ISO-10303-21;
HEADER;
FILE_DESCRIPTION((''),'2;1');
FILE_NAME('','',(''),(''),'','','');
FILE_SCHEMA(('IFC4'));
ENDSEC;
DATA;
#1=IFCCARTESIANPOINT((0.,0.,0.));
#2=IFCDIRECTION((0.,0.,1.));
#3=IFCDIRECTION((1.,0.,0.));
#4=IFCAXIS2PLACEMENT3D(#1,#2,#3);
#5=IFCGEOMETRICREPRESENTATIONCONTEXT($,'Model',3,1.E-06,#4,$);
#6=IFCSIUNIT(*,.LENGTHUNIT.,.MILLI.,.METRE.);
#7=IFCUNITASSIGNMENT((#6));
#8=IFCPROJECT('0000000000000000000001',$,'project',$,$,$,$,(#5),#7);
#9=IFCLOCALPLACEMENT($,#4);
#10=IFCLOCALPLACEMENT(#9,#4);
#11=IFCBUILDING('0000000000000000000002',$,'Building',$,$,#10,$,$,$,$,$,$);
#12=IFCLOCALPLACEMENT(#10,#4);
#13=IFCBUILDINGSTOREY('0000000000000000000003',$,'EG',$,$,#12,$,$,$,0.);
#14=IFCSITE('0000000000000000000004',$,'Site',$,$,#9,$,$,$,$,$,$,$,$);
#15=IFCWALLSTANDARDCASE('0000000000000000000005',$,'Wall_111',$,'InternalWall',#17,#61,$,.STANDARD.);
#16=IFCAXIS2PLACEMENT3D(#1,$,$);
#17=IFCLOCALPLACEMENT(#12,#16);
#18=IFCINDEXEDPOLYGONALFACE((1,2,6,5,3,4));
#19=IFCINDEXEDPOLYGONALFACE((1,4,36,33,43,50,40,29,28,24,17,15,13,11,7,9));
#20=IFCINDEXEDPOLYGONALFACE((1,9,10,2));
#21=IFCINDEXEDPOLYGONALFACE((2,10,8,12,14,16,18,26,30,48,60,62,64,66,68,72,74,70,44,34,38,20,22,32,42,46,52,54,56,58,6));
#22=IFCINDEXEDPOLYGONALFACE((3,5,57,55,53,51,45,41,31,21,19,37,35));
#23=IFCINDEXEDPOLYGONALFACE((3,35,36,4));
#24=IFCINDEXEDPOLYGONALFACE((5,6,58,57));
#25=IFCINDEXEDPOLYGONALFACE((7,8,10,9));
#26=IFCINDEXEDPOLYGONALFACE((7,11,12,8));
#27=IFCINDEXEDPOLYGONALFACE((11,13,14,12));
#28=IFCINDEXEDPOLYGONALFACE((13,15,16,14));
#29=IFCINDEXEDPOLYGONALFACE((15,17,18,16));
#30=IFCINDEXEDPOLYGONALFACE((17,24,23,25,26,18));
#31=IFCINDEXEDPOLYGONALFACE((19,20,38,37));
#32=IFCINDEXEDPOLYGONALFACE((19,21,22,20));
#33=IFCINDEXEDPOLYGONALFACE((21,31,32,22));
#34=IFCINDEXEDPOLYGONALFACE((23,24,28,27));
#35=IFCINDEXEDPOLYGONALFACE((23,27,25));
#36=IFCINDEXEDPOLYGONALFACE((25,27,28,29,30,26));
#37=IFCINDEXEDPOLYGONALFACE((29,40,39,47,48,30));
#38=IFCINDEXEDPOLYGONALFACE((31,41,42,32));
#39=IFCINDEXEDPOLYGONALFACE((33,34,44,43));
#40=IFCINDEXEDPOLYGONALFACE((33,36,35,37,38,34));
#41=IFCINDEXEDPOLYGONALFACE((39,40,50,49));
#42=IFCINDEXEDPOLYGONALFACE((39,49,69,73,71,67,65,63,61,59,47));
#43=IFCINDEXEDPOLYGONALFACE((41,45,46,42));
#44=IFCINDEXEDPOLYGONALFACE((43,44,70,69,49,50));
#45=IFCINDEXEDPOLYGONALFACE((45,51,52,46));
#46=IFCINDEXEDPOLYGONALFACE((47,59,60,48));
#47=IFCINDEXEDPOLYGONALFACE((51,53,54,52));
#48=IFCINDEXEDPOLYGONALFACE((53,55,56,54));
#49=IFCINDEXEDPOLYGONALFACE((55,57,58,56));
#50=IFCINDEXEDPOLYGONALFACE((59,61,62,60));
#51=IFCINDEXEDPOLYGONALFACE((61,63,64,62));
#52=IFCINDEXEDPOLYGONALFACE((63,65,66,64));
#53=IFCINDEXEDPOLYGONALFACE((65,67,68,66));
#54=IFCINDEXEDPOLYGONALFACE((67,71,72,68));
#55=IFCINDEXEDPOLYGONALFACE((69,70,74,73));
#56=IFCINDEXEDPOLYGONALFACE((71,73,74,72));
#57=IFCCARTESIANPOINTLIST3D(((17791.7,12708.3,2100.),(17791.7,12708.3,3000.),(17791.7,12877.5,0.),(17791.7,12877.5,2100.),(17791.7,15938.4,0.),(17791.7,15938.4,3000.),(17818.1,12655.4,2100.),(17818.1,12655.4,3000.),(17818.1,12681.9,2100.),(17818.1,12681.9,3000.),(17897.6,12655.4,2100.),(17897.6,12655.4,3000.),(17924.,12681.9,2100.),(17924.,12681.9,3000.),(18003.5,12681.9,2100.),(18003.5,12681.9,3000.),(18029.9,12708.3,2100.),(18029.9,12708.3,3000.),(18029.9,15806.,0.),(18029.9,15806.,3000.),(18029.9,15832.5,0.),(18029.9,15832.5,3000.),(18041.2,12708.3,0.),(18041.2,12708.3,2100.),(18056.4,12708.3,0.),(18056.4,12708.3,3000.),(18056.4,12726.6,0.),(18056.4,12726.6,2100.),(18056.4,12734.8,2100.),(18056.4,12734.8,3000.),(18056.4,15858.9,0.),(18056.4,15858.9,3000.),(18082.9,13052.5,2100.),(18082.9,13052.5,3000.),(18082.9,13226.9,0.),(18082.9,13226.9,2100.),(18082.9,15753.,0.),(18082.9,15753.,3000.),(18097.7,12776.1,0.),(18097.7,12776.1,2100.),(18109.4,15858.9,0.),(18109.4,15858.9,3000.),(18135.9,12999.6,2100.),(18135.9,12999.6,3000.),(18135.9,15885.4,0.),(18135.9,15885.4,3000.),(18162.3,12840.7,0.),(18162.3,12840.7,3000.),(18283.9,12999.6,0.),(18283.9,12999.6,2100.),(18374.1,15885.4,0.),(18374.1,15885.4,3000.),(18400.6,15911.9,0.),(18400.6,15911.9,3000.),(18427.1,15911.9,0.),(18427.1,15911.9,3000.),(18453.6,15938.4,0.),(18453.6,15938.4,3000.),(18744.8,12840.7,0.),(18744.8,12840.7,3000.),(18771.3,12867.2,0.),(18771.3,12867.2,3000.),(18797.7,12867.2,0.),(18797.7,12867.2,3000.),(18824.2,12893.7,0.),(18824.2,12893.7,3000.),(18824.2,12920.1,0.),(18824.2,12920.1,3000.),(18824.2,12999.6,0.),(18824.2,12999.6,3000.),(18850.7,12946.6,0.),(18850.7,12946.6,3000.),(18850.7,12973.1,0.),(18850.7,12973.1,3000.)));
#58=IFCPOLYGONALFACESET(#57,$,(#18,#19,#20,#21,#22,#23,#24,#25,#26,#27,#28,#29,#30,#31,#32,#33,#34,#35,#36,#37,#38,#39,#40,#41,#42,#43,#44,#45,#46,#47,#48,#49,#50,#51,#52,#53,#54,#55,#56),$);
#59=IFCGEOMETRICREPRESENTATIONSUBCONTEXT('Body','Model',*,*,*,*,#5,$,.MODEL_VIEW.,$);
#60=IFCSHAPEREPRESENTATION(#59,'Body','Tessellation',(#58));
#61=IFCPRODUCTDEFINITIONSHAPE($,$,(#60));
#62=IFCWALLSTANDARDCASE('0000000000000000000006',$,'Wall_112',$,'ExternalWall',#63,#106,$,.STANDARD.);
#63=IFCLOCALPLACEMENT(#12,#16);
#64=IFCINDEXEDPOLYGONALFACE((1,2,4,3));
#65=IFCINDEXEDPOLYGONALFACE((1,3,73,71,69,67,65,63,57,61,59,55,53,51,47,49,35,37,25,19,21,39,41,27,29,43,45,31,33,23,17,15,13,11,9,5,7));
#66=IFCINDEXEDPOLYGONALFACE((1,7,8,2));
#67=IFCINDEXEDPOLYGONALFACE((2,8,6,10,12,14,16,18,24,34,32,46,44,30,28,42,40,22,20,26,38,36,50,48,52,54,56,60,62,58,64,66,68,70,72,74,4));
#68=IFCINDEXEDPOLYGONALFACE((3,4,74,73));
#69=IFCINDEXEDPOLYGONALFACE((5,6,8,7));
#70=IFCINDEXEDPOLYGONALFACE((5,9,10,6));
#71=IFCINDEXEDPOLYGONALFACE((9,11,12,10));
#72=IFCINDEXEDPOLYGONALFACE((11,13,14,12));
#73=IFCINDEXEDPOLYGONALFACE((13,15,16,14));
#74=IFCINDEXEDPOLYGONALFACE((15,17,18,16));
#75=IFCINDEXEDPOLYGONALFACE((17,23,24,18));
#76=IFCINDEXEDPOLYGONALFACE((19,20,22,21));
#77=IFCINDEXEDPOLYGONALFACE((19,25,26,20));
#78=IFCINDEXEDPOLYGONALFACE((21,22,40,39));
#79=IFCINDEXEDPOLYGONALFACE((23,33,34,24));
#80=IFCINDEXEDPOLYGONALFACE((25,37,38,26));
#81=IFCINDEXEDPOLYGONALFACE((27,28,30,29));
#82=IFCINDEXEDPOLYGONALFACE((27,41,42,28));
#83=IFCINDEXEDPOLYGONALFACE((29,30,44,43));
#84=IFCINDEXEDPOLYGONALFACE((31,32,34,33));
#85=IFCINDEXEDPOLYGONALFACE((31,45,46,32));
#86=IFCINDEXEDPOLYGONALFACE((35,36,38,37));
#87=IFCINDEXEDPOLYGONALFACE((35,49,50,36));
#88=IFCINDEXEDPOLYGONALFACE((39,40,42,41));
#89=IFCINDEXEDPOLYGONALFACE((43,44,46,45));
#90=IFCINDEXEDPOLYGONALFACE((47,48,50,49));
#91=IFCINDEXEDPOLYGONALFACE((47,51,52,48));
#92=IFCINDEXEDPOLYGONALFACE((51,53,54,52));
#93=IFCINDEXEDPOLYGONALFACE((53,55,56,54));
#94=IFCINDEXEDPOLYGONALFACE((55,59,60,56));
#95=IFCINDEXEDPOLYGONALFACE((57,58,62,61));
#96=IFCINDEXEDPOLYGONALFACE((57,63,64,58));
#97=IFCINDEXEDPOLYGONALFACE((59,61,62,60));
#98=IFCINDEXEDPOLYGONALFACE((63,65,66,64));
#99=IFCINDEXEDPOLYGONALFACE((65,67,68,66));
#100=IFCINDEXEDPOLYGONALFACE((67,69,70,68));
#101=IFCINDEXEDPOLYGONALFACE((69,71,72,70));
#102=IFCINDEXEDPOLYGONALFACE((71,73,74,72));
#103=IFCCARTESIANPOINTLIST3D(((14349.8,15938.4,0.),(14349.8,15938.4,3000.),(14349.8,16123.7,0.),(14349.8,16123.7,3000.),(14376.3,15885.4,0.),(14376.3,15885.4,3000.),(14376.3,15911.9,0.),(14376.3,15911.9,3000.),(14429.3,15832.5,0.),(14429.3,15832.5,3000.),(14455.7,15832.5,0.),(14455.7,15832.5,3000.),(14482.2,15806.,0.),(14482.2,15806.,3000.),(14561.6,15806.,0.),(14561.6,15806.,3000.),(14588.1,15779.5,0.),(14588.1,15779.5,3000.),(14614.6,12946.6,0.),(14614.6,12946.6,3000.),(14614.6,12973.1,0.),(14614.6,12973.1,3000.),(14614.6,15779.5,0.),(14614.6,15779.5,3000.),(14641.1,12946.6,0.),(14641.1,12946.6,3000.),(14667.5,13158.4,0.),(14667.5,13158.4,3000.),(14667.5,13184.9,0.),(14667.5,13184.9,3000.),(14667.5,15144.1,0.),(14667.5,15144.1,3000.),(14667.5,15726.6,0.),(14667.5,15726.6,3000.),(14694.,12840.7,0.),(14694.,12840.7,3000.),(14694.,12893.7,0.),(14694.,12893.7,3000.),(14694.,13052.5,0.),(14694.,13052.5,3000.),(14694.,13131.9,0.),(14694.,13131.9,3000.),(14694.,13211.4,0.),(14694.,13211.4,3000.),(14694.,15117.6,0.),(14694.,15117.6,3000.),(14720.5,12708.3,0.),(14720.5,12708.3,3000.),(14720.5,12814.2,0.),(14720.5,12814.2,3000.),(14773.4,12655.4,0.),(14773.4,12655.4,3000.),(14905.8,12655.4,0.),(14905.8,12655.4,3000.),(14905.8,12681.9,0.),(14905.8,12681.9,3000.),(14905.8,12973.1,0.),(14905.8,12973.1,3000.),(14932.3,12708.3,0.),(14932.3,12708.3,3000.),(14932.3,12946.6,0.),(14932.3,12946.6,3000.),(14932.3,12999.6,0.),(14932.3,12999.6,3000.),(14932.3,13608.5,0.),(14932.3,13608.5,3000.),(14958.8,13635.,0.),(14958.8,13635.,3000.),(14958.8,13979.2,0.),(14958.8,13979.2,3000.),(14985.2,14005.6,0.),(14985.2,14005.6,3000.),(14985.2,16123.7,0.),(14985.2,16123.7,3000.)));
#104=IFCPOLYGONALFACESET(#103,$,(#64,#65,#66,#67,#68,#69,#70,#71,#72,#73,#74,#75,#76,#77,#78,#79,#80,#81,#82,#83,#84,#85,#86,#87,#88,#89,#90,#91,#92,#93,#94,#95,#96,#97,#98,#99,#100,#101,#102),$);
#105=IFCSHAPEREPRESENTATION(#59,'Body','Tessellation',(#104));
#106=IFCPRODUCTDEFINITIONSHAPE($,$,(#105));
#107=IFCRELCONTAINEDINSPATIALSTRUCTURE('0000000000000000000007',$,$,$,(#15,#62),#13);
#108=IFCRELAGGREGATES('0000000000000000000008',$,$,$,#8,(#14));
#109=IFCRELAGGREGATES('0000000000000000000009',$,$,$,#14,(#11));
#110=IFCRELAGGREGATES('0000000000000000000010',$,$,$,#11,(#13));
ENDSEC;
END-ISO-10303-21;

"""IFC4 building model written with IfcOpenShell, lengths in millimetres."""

from ifc_helpers import new_model, si_unit, frame, origin_with_axes, place, context, subcontext, project, spatial, polyline, rectangle, outline, extrude, element, save


model = new_model("IFC4")

# Units and contexts
model_context = context("Model", 3, precision=1e-06, world=origin_with_axes())
body_context = subcontext(model_context, "Body", "Model", "MODEL_VIEW")
ifc_project = project(units=[si_unit("LENGTHUNIT", "METRE", prefix="MILLI")], contexts=[model_context])

# Site, building, storey
site_placement = place(None, origin_with_axes())
site = spatial("IfcSite", under=ifc_project, at=site_placement, Name="Site")
building_placement = place(site_placement, origin_with_axes())
building = spatial("IfcBuilding", under=site, at=building_placement, Name="Building")
storey_placement = place(building_placement, origin_with_axes())
storey = spatial("IfcBuildingStorey", under=building, at=storey_placement, Name="EG", Elevation=0.0)

# Wall, opening
wall_1_placement = place(storey_placement, origin_with_axes())
wall_1 = element("IfcWallStandardCase", 1, at=wall_1_placement, inside=storey, Name="Wall_111", ObjectType="InternalWall", PredefinedType="STANDARD", context=body_context, shape_type="SweptSolid", body=[
    extrude(outline(polyline([(17818.1, 12655.4, 0.0), (17818.1, 12681.9, 0.0), (17791.7, 12708.3, 0.0), (17791.7, 15938.4, 0.0), (18453.6, 15938.4, 0.0), (18427.1, 15911.9, 0.0), (18400.6, 15911.9, 0.0), (18374.1, 15885.4, 0.0), (18135.9, 15885.4, 0.0), (18109.4, 15858.9, 0.0), (18056.4, 15858.9, 0.0), (18029.9, 15832.5, 0.0), (18029.9, 15806.0, 0.0), (18082.9, 15753.0, 0.0), (18082.9, 13052.5, 0.0), (18135.9, 12999.6, 0.0), (18824.2, 12999.6, 0.0), (18850.7, 12973.1, 0.0), (18850.7, 12946.6, 0.0), (18824.2, 12920.1, 0.0), (18824.2, 12893.7, 0.0), (18797.7, 12867.2, 0.0), (18771.3, 12867.2, 0.0), (18744.8, 12840.7, 0.0), (18162.3, 12840.7, 0.0), (18056.4, 12734.8, 0.0), (18056.4, 12708.3, 0.0), (18029.9, 12708.3, 0.0), (18003.5, 12681.9, 0.0), (17924.0, 12681.9, 0.0), (17897.6, 12655.4, 0.0), (17818.1, 12655.4, 0.0)])), origin_with_axes(), (0.0, 0.0, 1.0), 3000.0),
])
opening_1_placement = place(wall_1_placement, origin_with_axes())
element("IfcOpeningElement", 2, at=opening_1_placement, inside=storey, cuts=wall_1, context=body_context, shape_type="SweptSolid", body=[
    extrude(rectangle(XDim=1440.7, YDim=300.0), frame((17781.4, 12630.8, 0.0), z_axis=(0.0, 0.0, 1.0), x_axis=(-0.640184, -0.768221, 0.0)), (0.0, 0.0, 1.0), 2100.0),
])

# Wall
for number, where, z_axis, x_axis, name in (
    (3, (0.0, 0.0, 0.0), (0.0, 0.0, 1.0), (1.0, 0.0, 0.0), "Wall_112"),
):
    element("IfcWallStandardCase", number, at=place(storey_placement, frame(where, z_axis=z_axis, x_axis=x_axis)), inside=storey, Name=name, ObjectType="ExternalWall", PredefinedType="STANDARD", context=body_context, shape_type="SweptSolid", body=[
        extrude(outline(polyline([(14773.4, 12655.4, 0.0), (14720.5, 12708.3, 0.0), (14720.5, 12814.2, 0.0), (14694.0, 12840.7, 0.0), (14694.0, 12893.7, 0.0), (14641.1, 12946.6, 0.0), (14614.6, 12946.6, 0.0), (14614.6, 12973.1, 0.0), (14694.0, 13052.5, 0.0), (14694.0, 13131.9, 0.0), (14667.5, 13158.4, 0.0), (14667.5, 13184.9, 0.0), (14694.0, 13211.4, 0.0), (14694.0, 15117.6, 0.0), (14667.5, 15144.1, 0.0), (14667.5, 15726.6, 0.0), (14614.6, 15779.5, 0.0), (14588.1, 15779.5, 0.0), (14561.6, 15806.0, 0.0), (14482.2, 15806.0, 0.0), (14455.7, 15832.5, 0.0), (14429.3, 15832.5, 0.0), (14376.3, 15885.4, 0.0), (14376.3, 15911.9, 0.0), (14349.8, 15938.4, 0.0), (14349.8, 16123.7, 0.0), (14985.2, 16123.7, 0.0), (14985.2, 14005.6, 0.0), (14958.8, 13979.2, 0.0), (14958.8, 13635.0, 0.0), (14932.3, 13608.5, 0.0), (14932.3, 12999.6, 0.0), (14905.8, 12973.1, 0.0), (14932.3, 12946.6, 0.0), (14932.3, 12708.3, 0.0), (14905.8, 12681.9, 0.0), (14905.8, 12655.4, 0.0), (14773.4, 12655.4, 0.0)])), origin_with_axes(), (0.0, 0.0, 1.0), 3000.0),
    ])

save(model, "model.ifc")
